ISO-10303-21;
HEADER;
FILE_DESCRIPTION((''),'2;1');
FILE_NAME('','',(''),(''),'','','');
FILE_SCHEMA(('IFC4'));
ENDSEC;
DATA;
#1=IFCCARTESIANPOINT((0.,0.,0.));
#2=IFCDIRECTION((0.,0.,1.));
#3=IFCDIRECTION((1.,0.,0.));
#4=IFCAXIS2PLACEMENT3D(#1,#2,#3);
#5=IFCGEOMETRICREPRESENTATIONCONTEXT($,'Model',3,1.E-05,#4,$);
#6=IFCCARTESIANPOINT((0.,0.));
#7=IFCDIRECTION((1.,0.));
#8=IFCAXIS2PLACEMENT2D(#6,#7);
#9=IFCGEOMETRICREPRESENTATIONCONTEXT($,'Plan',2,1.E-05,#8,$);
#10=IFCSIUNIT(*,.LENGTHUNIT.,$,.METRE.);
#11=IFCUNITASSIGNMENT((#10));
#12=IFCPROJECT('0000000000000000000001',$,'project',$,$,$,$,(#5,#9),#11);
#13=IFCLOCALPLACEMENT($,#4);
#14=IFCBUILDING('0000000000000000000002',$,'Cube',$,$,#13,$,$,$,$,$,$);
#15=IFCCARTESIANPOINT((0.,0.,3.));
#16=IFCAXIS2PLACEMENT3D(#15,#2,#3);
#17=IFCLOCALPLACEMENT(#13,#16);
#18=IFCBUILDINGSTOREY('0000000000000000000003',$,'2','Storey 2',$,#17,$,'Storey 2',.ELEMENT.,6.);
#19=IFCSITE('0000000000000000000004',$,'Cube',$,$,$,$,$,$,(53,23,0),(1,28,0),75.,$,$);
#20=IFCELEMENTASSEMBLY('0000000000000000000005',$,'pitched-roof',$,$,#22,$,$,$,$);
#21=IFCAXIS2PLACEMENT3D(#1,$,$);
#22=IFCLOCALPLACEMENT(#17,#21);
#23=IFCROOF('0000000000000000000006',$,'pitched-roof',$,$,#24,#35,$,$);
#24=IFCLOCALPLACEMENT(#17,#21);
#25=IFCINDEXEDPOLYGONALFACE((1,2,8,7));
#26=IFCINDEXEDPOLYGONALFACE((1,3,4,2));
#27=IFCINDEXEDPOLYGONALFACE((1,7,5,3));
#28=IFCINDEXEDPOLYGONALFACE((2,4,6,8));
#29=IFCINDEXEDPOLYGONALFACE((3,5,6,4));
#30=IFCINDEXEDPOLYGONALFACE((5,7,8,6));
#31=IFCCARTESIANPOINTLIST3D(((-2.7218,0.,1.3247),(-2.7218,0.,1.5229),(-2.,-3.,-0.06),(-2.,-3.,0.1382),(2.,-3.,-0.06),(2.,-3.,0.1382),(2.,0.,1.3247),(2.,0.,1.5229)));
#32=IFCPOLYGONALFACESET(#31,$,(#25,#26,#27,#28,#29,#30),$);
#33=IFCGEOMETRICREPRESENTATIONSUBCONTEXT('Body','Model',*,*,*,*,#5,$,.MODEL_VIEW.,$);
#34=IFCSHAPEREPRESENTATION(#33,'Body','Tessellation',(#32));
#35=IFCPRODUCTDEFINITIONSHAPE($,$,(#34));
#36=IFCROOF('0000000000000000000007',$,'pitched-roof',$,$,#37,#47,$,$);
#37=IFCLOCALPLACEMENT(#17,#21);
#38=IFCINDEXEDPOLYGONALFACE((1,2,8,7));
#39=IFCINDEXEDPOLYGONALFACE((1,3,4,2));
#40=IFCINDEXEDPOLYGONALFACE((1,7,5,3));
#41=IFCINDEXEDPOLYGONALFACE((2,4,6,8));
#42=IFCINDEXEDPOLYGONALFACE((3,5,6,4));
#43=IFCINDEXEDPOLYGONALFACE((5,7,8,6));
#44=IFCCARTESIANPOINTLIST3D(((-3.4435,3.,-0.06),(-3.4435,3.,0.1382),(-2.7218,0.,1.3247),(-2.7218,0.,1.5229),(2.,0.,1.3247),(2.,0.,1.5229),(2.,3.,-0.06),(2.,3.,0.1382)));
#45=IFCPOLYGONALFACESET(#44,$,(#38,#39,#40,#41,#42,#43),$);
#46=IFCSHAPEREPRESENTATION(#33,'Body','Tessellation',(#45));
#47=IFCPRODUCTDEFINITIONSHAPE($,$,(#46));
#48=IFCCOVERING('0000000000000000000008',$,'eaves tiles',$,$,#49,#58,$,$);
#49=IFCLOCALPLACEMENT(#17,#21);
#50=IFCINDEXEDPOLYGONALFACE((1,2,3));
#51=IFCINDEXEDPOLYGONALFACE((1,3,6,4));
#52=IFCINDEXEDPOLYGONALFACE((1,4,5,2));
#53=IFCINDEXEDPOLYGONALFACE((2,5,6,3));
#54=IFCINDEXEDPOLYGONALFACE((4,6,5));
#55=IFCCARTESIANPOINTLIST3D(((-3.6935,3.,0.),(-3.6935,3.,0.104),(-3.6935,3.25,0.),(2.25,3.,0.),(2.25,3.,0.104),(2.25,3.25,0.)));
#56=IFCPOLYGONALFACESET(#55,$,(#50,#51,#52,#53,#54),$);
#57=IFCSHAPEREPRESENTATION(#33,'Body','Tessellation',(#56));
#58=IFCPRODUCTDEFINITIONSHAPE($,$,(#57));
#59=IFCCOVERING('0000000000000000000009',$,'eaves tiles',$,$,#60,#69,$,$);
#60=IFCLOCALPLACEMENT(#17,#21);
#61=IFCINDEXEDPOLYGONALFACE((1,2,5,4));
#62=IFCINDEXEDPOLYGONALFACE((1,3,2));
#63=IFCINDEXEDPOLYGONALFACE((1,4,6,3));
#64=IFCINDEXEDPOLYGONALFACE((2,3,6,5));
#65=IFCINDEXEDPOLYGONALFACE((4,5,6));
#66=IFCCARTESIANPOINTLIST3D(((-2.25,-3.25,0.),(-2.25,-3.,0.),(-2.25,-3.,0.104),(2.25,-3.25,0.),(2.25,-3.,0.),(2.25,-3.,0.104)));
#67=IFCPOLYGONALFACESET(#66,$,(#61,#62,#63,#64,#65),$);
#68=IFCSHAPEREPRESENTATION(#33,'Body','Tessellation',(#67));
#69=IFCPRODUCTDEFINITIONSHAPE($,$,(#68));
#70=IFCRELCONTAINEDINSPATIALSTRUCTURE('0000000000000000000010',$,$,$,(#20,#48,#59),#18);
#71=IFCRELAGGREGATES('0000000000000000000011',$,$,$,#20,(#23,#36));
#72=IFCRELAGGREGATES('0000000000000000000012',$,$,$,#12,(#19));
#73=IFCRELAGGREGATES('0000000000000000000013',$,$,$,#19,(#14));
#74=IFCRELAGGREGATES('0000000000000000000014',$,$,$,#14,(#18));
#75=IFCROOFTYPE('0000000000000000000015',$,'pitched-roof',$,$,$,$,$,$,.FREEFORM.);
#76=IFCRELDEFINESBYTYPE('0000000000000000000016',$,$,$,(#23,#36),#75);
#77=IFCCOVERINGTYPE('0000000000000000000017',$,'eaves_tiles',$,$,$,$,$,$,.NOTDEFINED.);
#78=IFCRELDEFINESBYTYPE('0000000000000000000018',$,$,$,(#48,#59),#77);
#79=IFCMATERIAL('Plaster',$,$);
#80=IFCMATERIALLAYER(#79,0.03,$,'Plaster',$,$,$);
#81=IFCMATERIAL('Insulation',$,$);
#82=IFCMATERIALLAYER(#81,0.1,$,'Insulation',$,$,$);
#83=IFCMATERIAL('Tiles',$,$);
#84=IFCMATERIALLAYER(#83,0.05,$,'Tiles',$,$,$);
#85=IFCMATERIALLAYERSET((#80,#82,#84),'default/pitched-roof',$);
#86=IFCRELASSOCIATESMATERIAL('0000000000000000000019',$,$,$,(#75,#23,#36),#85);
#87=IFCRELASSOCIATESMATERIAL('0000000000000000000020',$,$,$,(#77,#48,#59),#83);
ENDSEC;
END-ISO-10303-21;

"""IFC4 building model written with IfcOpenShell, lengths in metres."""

from ifc_helpers import new_model, si_unit, frame, origin, origin_with_axes, origin_2d_with_axis, place, context, subcontext, project, spatial, polyline, outline, extrude, material, layer, layer_set, layer_usage, material_profile, profile_set, profile_usage, type_object, element, aggregate, save


model = new_model("IFC4")

# Units and contexts
model_context = context("Model", 3, precision=1e-05, world=origin_with_axes())
plan_context = context("Plan", 2, precision=1e-05, world=origin_2d_with_axis())
body_context = subcontext(model_context, "Body", "Model", "MODEL_VIEW")
ifc_project = project(units=[si_unit("LENGTHUNIT", "METRE")], contexts=[model_context, plan_context])

# Site, building, storey
site = spatial("IfcSite", under=ifc_project, Name="Cube", RefLatitude=(53, 23, 0), RefLongitude=(1, 28, 0), RefElevation=75.0)
building_placement = place(None, origin_with_axes())
building = spatial("IfcBuilding", under=site, at=building_placement, Name="Cube")
storey_placement = place(building_placement, frame((0.0, 0.0, 3.0), z_axis=(0.0, 0.0, 1.0), x_axis=(1.0, 0.0, 0.0)))
storey = spatial("IfcBuildingStorey", under=building, at=storey_placement, Name="2", Description="Storey 2", LongName="Storey 2", CompositionType="ELEMENT", Elevation=6.0)

# Element assembly, roofs
assembly_placement = place(storey_placement, frame((0.0, 0.0, -3.0), z_axis=(0.0, 0.0, 1.0), x_axis=(1.0, 0.0, 0.0)))
assembly = element("IfcElementAssembly", 1, at=assembly_placement, inside=storey, Name="pitched-roof")
ifc_material_1 = material(Name="Plaster")
ifc_layer_1 = layer(ifc_material_1, 0.03, Name="Plaster")
ifc_material_2 = material(Name="Insulation")
ifc_layer_2 = layer(ifc_material_2, 0.1, Name="Insulation")
ifc_material_3 = material(Name="Tiles")
ifc_layer_3 = layer(ifc_material_3, 0.05, Name="Tiles")
ifc_layer_set = layer_set([ifc_layer_1, ifc_layer_2, ifc_layer_3], Name="default/pitched-roof")
ifc_layer_usage_1 = layer_usage(ifc_layer_set, "AXIS3", "POSITIVE", 0.0)
roof_type = type_object("IfcRoofType", Name="pitched-roof", PredefinedType="FREEFORM", material=ifc_layer_set)
roof_1_placement = place(assembly_placement, frame((-2.0, -3.0, 2.94), z_axis=(0.0, -0.419069, 0.907954), x_axis=(1.0, 0.0, 0.0)))
roof_1 = element("IfcRoof", 2, at=roof_1_placement, type_object=roof_type, material=ifc_layer_usage_1, Name="pitched-roof", context=body_context, shape_type="SweptSolid", body=[
    extrude(outline(polyline([(0.0, 0.0), (4.0, 0.0), (4.0, 3.3041), (-0.7218, 3.3041), (0.0, 0.0)])), origin(), (0.0, 0.419069, 0.907954), 0.1982),
])
ifc_layer_usage_2 = layer_usage(ifc_layer_set, "AXIS3", "POSITIVE", 0.0)
roof_2_placement = place(assembly_placement, frame((-3.4435, 3.0, 2.94), z_axis=(0.0, 0.419069, 0.907954), x_axis=(-1.0, 0.0, 0.0)))
roof_2 = element("IfcRoof", 3, at=roof_2_placement, type_object=roof_type, material=ifc_layer_usage_2, Name="pitched-roof", context=body_context, shape_type="SweptSolid", body=[
    extrude(outline(polyline([(0.0, 0.0), (-0.7218, 3.3041), (-5.4435, 3.3041), (-5.4435, 0.0), (0.0, 0.0)])), origin(), (0.0, 0.419069, 0.907954), 0.1982),
])
aggregate(assembly, [roof_1, roof_2])

# Coverings
ifc_material_profile_1 = material_profile(ifc_material_3, outline(polyline([(0.25, 0.0), (0.0, 0.0), (0.0, 0.104), (0.25, 0.0)])))
ifc_profile_set_1 = profile_set([ifc_material_profile_1])
ifc_profile_usage_1 = profile_usage(ifc_profile_set_1)
covering_type_1 = type_object("IfcCoveringType", Name="eaves_tiles", PredefinedType="NOTDEFINED", material=ifc_profile_set_1)
covering_1_placement = place(storey_placement, frame((-3.6935, 3.0, 0.0), z_axis=(1.0, 0.0, 0.0), x_axis=(0.0, 1.0, 0.0)))
element("IfcCovering", 4, at=covering_1_placement, inside=storey, type_object=covering_type_1, material=ifc_profile_usage_1, Name="eaves tiles", context=body_context, shape_type="SweptSolid", body=[
    extrude(outline(polyline([(0.25, 0.0), (0.0, 0.0), (0.0, 0.104), (0.25, 0.0)])), origin_with_axes(), (0.0, 0.0, 1.0), 5.9435),
])
ifc_profile_usage_2 = profile_usage(ifc_profile_set_1)
covering_2_placement = place(storey_placement, frame((2.25, -3.0, 0.0), z_axis=(-1.0, 0.0, 0.0), x_axis=(0.0, -1.0, 0.0)))
element("IfcCovering", 5, at=covering_2_placement, inside=storey, type_object=covering_type_1, material=ifc_profile_usage_2, Name="eaves tiles", context=body_context, shape_type="SweptSolid", body=[
    extrude(outline(polyline([(0.25, 0.0), (0.0, 0.0), (0.0, 0.104), (0.25, 0.0)])), origin_with_axes(), (0.0, 0.0, 1.0), 4.5),
])

save(model, "model.ifc")
